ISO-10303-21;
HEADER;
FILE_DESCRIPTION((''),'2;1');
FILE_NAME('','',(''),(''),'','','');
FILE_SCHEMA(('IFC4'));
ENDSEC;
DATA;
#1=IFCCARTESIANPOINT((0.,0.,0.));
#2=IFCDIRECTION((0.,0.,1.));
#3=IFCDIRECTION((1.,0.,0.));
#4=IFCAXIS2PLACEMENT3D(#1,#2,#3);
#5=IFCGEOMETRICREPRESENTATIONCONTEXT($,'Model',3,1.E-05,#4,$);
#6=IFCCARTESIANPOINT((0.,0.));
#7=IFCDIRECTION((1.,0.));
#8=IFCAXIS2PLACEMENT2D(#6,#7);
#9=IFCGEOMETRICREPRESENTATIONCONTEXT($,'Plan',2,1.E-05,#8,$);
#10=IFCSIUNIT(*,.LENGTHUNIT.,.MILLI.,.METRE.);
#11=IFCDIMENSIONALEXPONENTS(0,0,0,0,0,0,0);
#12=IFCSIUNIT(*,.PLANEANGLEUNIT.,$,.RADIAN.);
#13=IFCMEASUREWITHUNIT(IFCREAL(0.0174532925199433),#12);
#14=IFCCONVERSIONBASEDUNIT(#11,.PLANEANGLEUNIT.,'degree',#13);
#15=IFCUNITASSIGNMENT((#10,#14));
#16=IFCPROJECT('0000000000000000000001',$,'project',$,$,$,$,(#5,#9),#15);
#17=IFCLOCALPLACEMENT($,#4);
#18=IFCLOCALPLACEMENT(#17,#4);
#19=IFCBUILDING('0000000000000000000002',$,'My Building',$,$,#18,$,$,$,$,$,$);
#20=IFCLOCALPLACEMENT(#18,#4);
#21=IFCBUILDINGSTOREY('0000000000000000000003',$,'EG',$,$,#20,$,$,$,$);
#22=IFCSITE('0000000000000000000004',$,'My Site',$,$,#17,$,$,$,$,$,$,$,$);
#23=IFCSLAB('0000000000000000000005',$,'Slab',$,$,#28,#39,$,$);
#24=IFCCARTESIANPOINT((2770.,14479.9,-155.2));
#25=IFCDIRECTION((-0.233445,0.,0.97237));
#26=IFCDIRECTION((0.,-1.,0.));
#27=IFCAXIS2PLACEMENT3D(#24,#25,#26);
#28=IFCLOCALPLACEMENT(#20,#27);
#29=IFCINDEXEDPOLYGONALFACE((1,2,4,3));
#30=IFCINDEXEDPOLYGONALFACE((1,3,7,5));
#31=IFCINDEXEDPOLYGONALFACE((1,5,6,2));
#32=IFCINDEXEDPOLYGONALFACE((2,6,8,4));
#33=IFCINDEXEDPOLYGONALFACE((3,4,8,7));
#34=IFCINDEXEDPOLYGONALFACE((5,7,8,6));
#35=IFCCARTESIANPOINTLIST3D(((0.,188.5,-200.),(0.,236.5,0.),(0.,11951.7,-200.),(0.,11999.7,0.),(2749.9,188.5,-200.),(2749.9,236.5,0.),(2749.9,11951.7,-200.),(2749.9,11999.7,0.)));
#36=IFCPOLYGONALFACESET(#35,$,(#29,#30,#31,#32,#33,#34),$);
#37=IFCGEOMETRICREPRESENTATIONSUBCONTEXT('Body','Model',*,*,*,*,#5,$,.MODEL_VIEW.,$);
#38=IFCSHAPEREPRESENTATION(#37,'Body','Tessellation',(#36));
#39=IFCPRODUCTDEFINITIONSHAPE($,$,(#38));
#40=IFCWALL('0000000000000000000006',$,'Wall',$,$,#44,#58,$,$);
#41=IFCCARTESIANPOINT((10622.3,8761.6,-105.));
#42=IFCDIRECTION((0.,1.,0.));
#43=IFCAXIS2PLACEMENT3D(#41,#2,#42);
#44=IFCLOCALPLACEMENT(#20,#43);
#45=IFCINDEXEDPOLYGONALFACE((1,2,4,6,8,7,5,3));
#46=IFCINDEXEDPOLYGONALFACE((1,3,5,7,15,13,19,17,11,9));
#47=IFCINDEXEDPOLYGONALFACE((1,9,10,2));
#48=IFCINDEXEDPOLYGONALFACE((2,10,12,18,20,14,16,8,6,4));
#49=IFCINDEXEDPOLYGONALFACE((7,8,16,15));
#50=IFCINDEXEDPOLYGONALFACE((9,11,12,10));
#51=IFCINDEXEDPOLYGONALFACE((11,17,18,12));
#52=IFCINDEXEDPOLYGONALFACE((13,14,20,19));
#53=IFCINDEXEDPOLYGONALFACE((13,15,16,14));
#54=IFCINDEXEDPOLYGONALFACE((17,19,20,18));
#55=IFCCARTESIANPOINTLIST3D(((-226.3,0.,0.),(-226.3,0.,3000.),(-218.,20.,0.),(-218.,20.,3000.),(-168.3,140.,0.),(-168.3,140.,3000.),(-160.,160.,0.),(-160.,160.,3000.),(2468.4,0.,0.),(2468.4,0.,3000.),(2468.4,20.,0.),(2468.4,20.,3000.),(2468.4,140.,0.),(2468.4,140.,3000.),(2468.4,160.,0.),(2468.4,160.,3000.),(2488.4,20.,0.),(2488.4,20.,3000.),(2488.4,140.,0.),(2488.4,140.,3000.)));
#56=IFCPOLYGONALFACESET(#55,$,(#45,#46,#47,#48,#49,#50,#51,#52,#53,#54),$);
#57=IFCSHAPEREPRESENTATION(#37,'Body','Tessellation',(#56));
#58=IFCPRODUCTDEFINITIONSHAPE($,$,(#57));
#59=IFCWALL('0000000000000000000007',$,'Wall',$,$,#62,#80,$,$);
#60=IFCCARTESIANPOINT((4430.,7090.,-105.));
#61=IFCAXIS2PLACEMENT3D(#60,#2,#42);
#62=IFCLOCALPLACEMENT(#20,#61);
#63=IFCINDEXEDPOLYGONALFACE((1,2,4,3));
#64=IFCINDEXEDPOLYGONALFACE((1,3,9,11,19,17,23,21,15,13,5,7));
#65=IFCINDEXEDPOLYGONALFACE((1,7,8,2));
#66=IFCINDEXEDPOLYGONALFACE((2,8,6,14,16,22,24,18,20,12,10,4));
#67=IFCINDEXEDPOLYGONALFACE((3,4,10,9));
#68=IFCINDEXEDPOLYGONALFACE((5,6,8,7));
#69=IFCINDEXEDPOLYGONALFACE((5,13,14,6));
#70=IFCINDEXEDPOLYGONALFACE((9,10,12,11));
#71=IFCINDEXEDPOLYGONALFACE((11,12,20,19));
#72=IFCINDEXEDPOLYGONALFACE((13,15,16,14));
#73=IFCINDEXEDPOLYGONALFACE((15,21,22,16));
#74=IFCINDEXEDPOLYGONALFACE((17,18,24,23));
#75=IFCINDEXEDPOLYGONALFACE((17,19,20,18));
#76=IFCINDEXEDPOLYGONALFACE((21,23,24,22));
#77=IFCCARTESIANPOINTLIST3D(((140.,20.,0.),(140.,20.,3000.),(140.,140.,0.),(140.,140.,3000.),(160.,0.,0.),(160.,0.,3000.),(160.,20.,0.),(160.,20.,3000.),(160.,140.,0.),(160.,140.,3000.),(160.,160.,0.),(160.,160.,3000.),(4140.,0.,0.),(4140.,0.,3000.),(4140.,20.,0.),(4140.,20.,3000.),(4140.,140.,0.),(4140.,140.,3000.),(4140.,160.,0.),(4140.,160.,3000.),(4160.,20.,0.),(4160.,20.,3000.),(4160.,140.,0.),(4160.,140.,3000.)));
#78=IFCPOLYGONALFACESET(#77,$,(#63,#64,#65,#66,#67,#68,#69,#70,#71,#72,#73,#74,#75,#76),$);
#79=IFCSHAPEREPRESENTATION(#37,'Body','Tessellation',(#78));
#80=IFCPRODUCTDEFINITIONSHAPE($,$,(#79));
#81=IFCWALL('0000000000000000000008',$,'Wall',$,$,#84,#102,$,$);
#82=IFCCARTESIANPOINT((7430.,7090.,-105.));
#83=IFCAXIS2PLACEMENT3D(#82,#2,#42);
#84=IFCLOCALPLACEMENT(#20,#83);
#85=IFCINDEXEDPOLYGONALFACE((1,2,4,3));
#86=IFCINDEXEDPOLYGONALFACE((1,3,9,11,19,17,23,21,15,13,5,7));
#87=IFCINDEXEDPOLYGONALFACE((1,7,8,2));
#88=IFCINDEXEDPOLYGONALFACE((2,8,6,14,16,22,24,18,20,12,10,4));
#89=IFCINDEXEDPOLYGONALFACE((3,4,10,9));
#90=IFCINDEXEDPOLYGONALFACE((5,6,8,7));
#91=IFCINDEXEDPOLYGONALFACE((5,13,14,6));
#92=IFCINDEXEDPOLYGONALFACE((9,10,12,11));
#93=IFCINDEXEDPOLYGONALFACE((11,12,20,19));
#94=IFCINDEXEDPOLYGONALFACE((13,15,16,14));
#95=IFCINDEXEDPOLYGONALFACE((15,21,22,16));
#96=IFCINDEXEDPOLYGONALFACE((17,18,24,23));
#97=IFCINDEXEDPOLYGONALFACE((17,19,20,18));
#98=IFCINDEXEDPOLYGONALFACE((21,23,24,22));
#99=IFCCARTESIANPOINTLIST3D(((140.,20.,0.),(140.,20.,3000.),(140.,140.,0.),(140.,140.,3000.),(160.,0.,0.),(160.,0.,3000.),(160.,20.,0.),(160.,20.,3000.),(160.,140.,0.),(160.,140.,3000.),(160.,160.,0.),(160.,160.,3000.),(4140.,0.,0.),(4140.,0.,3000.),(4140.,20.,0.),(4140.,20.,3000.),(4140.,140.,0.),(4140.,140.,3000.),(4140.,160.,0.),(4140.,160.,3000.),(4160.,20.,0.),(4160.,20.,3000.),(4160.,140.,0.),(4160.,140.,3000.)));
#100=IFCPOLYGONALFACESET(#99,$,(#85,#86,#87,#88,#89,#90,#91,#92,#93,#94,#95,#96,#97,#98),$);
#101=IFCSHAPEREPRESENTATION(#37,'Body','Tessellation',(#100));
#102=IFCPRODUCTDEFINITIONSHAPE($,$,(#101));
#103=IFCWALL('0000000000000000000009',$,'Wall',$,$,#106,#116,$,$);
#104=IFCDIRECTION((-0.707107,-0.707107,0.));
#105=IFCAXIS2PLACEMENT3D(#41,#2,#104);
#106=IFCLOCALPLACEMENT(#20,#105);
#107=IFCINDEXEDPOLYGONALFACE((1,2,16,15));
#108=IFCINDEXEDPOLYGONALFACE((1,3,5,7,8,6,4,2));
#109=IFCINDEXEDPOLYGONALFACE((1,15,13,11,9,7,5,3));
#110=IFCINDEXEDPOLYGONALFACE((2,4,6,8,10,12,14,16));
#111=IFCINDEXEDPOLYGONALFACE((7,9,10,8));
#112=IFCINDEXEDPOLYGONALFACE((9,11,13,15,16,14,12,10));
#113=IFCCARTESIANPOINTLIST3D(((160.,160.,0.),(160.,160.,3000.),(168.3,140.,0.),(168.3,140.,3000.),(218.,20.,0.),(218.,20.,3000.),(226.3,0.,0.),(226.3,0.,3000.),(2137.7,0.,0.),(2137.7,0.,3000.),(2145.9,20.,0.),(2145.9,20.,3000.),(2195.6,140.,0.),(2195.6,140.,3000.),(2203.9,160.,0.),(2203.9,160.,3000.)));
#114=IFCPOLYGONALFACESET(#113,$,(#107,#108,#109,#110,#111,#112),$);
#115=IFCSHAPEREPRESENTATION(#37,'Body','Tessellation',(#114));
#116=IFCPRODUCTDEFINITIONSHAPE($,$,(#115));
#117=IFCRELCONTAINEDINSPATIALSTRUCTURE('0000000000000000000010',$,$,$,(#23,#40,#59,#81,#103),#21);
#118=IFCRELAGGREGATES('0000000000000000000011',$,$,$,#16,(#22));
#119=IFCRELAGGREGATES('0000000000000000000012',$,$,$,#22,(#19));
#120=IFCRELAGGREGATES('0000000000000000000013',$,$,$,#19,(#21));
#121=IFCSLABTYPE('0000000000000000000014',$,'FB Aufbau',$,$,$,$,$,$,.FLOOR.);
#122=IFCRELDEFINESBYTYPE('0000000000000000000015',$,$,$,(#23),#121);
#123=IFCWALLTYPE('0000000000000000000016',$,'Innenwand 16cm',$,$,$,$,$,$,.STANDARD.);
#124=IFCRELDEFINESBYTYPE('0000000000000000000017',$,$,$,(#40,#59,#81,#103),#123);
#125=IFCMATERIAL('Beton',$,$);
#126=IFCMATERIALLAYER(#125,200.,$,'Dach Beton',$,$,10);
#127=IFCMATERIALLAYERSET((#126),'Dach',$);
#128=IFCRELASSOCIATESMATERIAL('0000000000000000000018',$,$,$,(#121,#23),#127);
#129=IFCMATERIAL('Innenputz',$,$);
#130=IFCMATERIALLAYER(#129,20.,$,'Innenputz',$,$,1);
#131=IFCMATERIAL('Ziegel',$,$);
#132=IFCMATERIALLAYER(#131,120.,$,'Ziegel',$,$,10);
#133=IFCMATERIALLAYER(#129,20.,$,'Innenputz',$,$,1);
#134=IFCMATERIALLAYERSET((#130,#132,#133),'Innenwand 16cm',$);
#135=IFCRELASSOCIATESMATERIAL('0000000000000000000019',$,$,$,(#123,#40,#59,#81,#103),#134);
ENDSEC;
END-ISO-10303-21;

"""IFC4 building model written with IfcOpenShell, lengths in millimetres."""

from ifc_helpers import new_model, entity, si_unit, converted_unit, frame, origin_with_axes, origin_2d_with_axis, place, context, subcontext, project, spatial, line, indexed_curve, outline, extrude, material, layer, layer_set, layer_usage, type_object, element, save


model = new_model("IFC4")

# Units and contexts
model_context = context("Model", 3, precision=1e-05, world=origin_with_axes())
plan_context = context("Plan", 2, precision=1e-05, world=origin_2d_with_axis())
body_context = subcontext(model_context, "Body", "Model", "MODEL_VIEW")
ifc_project = project(units=[si_unit("LENGTHUNIT", "METRE", prefix="MILLI"), converted_unit("PLANEANGLEUNIT", "degree", entity("IfcReal", 0.0174532925199433), si_unit("PLANEANGLEUNIT", "RADIAN"), dimensions=[0, 0, 0, 0, 0, 0, 0])], contexts=[model_context, plan_context])

# Site, building, storey
site_placement = place(None, origin_with_axes())
site = spatial("IfcSite", under=ifc_project, at=site_placement, Name="My Site")
building_placement = place(site_placement, origin_with_axes())
building = spatial("IfcBuilding", under=site, at=building_placement, Name="My Building")
storey_placement = place(building_placement, origin_with_axes())
storey = spatial("IfcBuildingStorey", under=building, at=storey_placement, Name="EG")

# Slab
ifc_material_1 = material(Name="Beton")
ifc_layer_1 = layer(ifc_material_1, 200.0, Name="Dach Beton", Priority=10)
ifc_layer_set_1 = layer_set([ifc_layer_1], Name="Dach")
slab_type = type_object("IfcSlabType", Name="FB Aufbau", PredefinedType="FLOOR", material=ifc_layer_set_1)
ifc_layer_usage_1 = layer_usage(ifc_layer_set_1, "AXIS3", "POSITIVE", -200.0)
slab_1_placement = place(storey_placement, frame((2770.0, 14479.9, -155.2), z_axis=(-0.233445, 0.0, 0.97237), x_axis=(0.0, -1.0, 0.0)))
element("IfcSlab", 1, at=slab_1_placement, inside=storey, type_object=slab_type, material=ifc_layer_usage_1, Name="Slab", context=body_context, shape_type="SweptSolid", body=[
    extrude(outline(indexed_curve([(0.0, 236.5), (2749.9, 236.5), (2749.9, 11999.7), (0.0, 11999.7), (0.0, 236.5)])), frame((0.0, -48.0, -200.0), z_axis=(0.0, 0.0, 1.0), x_axis=(1.0, 0.0, 0.0)), (0.0, 0.233445, 0.97237), 205.7),
])

# Walls
ifc_material_2 = material(Name="Innenputz")
ifc_material_3 = material(Name="Ziegel")
ifc_layer_2 = layer(ifc_material_2, 20.0, Name="Innenputz", Priority=1)
ifc_layer_3 = layer(ifc_material_3, 120.0, Name="Ziegel", Priority=10)
ifc_layer_4 = layer(ifc_material_2, 20.0, Name="Innenputz", Priority=1)
ifc_layer_set_2 = layer_set([ifc_layer_2, ifc_layer_3, ifc_layer_4], Name="Innenwand 16cm")
wall_type_1 = type_object("IfcWallType", Name="Innenwand 16cm", PredefinedType="STANDARD", material=ifc_layer_set_2)
ifc_layer_usage_2 = layer_usage(ifc_layer_set_2, "AXIS2", "POSITIVE", 0.0)
wall_1_placement = place(storey_placement, frame((10622.3, 8761.6, -105.0), z_axis=(0.0, 0.0, 1.0), x_axis=(0.0, 1.0, 0.0)))
element("IfcWall", 2, at=wall_1_placement, inside=storey, type_object=wall_type_1, material=ifc_layer_usage_2, Name="Wall", context=body_context, shape_type="SweptSolid", body=[
    extrude(outline(indexed_curve([(-226.3, 0.0), (-218.0, 20.0), (-168.3, 140.0), (-160.0, 160.0), (2468.4, 160.0), (2468.4, 140.0), (2488.4, 140.0), (2488.4, 20.0), (2468.4, 20.0), (2468.4, 0.0)], segments=[line(1, 2, 3, 4, 5, 6, 7, 8, 9, 10, 1)])), origin_with_axes(), (0.0, 0.0, 1.0), 3000.0),
])
ifc_layer_usage_3 = layer_usage(ifc_layer_set_2, "AXIS2", "POSITIVE", 0.0)
wall_2_placement = place(storey_placement, frame((4430.0, 7090.0, -105.0), z_axis=(0.0, 0.0, 1.0), x_axis=(0.0, 1.0, 0.0)))
element("IfcWall", 3, at=wall_2_placement, inside=storey, type_object=wall_type_1, material=ifc_layer_usage_3, Name="Wall", context=body_context, shape_type="SweptSolid", body=[
    extrude(outline(indexed_curve([(160.0, 0.0), (160.0, 20.0), (140.0, 20.0), (140.0, 140.0), (160.0, 140.0), (160.0, 160.0), (4140.0, 160.0), (4140.0, 140.0), (4160.0, 140.0), (4160.0, 20.0), (4140.0, 20.0), (4140.0, 0.0)], segments=[line(1, 2, 3, 4, 5, 6, 7, 8, 9, 10, 11, 12, 1)])), origin_with_axes(), (0.0, 0.0, 1.0), 3000.0),
])
ifc_layer_usage_4 = layer_usage(ifc_layer_set_2, "AXIS2", "POSITIVE", 0.0)
wall_3_placement = place(storey_placement, frame((7430.0, 7090.0, -105.0), z_axis=(0.0, 0.0, 1.0), x_axis=(0.0, 1.0, 0.0)))
element("IfcWall", 4, at=wall_3_placement, inside=storey, type_object=wall_type_1, material=ifc_layer_usage_4, Name="Wall", context=body_context, shape_type="SweptSolid", body=[
    extrude(outline(indexed_curve([(160.0, 0.0), (160.0, 20.0), (140.0, 20.0), (140.0, 140.0), (160.0, 140.0), (160.0, 160.0), (4140.0, 160.0), (4140.0, 140.0), (4160.0, 140.0), (4160.0, 20.0), (4140.0, 20.0), (4140.0, 0.0)], segments=[line(1, 2, 3, 4, 5, 6, 7, 8, 9, 10, 11, 12, 1)])), origin_with_axes(), (0.0, 0.0, 1.0), 3000.0),
])
ifc_layer_usage_5 = layer_usage(ifc_layer_set_2, "AXIS2", "POSITIVE", 0.0)
wall_4_placement = place(storey_placement, frame((10622.3, 8761.6, -105.0), z_axis=(0.0, 0.0, 1.0), x_axis=(-0.707107, -0.707107, 0.0)))
element("IfcWall", 5, at=wall_4_placement, inside=storey, type_object=wall_type_1, material=ifc_layer_usage_5, Name="Wall", context=body_context, shape_type="SweptSolid", body=[
    extrude(outline(indexed_curve([(226.3, 0.0), (218.0, 20.0), (168.3, 140.0), (160.0, 160.0), (2203.9, 160.0), (2195.6, 140.0), (2145.9, 20.0), (2137.7, 0.0)], segments=[line(1, 2, 3, 4, 5, 6, 7, 8, 1)])), origin_with_axes(), (0.0, 0.0, 1.0), 3000.0),
])

save(model, "model.ifc")
